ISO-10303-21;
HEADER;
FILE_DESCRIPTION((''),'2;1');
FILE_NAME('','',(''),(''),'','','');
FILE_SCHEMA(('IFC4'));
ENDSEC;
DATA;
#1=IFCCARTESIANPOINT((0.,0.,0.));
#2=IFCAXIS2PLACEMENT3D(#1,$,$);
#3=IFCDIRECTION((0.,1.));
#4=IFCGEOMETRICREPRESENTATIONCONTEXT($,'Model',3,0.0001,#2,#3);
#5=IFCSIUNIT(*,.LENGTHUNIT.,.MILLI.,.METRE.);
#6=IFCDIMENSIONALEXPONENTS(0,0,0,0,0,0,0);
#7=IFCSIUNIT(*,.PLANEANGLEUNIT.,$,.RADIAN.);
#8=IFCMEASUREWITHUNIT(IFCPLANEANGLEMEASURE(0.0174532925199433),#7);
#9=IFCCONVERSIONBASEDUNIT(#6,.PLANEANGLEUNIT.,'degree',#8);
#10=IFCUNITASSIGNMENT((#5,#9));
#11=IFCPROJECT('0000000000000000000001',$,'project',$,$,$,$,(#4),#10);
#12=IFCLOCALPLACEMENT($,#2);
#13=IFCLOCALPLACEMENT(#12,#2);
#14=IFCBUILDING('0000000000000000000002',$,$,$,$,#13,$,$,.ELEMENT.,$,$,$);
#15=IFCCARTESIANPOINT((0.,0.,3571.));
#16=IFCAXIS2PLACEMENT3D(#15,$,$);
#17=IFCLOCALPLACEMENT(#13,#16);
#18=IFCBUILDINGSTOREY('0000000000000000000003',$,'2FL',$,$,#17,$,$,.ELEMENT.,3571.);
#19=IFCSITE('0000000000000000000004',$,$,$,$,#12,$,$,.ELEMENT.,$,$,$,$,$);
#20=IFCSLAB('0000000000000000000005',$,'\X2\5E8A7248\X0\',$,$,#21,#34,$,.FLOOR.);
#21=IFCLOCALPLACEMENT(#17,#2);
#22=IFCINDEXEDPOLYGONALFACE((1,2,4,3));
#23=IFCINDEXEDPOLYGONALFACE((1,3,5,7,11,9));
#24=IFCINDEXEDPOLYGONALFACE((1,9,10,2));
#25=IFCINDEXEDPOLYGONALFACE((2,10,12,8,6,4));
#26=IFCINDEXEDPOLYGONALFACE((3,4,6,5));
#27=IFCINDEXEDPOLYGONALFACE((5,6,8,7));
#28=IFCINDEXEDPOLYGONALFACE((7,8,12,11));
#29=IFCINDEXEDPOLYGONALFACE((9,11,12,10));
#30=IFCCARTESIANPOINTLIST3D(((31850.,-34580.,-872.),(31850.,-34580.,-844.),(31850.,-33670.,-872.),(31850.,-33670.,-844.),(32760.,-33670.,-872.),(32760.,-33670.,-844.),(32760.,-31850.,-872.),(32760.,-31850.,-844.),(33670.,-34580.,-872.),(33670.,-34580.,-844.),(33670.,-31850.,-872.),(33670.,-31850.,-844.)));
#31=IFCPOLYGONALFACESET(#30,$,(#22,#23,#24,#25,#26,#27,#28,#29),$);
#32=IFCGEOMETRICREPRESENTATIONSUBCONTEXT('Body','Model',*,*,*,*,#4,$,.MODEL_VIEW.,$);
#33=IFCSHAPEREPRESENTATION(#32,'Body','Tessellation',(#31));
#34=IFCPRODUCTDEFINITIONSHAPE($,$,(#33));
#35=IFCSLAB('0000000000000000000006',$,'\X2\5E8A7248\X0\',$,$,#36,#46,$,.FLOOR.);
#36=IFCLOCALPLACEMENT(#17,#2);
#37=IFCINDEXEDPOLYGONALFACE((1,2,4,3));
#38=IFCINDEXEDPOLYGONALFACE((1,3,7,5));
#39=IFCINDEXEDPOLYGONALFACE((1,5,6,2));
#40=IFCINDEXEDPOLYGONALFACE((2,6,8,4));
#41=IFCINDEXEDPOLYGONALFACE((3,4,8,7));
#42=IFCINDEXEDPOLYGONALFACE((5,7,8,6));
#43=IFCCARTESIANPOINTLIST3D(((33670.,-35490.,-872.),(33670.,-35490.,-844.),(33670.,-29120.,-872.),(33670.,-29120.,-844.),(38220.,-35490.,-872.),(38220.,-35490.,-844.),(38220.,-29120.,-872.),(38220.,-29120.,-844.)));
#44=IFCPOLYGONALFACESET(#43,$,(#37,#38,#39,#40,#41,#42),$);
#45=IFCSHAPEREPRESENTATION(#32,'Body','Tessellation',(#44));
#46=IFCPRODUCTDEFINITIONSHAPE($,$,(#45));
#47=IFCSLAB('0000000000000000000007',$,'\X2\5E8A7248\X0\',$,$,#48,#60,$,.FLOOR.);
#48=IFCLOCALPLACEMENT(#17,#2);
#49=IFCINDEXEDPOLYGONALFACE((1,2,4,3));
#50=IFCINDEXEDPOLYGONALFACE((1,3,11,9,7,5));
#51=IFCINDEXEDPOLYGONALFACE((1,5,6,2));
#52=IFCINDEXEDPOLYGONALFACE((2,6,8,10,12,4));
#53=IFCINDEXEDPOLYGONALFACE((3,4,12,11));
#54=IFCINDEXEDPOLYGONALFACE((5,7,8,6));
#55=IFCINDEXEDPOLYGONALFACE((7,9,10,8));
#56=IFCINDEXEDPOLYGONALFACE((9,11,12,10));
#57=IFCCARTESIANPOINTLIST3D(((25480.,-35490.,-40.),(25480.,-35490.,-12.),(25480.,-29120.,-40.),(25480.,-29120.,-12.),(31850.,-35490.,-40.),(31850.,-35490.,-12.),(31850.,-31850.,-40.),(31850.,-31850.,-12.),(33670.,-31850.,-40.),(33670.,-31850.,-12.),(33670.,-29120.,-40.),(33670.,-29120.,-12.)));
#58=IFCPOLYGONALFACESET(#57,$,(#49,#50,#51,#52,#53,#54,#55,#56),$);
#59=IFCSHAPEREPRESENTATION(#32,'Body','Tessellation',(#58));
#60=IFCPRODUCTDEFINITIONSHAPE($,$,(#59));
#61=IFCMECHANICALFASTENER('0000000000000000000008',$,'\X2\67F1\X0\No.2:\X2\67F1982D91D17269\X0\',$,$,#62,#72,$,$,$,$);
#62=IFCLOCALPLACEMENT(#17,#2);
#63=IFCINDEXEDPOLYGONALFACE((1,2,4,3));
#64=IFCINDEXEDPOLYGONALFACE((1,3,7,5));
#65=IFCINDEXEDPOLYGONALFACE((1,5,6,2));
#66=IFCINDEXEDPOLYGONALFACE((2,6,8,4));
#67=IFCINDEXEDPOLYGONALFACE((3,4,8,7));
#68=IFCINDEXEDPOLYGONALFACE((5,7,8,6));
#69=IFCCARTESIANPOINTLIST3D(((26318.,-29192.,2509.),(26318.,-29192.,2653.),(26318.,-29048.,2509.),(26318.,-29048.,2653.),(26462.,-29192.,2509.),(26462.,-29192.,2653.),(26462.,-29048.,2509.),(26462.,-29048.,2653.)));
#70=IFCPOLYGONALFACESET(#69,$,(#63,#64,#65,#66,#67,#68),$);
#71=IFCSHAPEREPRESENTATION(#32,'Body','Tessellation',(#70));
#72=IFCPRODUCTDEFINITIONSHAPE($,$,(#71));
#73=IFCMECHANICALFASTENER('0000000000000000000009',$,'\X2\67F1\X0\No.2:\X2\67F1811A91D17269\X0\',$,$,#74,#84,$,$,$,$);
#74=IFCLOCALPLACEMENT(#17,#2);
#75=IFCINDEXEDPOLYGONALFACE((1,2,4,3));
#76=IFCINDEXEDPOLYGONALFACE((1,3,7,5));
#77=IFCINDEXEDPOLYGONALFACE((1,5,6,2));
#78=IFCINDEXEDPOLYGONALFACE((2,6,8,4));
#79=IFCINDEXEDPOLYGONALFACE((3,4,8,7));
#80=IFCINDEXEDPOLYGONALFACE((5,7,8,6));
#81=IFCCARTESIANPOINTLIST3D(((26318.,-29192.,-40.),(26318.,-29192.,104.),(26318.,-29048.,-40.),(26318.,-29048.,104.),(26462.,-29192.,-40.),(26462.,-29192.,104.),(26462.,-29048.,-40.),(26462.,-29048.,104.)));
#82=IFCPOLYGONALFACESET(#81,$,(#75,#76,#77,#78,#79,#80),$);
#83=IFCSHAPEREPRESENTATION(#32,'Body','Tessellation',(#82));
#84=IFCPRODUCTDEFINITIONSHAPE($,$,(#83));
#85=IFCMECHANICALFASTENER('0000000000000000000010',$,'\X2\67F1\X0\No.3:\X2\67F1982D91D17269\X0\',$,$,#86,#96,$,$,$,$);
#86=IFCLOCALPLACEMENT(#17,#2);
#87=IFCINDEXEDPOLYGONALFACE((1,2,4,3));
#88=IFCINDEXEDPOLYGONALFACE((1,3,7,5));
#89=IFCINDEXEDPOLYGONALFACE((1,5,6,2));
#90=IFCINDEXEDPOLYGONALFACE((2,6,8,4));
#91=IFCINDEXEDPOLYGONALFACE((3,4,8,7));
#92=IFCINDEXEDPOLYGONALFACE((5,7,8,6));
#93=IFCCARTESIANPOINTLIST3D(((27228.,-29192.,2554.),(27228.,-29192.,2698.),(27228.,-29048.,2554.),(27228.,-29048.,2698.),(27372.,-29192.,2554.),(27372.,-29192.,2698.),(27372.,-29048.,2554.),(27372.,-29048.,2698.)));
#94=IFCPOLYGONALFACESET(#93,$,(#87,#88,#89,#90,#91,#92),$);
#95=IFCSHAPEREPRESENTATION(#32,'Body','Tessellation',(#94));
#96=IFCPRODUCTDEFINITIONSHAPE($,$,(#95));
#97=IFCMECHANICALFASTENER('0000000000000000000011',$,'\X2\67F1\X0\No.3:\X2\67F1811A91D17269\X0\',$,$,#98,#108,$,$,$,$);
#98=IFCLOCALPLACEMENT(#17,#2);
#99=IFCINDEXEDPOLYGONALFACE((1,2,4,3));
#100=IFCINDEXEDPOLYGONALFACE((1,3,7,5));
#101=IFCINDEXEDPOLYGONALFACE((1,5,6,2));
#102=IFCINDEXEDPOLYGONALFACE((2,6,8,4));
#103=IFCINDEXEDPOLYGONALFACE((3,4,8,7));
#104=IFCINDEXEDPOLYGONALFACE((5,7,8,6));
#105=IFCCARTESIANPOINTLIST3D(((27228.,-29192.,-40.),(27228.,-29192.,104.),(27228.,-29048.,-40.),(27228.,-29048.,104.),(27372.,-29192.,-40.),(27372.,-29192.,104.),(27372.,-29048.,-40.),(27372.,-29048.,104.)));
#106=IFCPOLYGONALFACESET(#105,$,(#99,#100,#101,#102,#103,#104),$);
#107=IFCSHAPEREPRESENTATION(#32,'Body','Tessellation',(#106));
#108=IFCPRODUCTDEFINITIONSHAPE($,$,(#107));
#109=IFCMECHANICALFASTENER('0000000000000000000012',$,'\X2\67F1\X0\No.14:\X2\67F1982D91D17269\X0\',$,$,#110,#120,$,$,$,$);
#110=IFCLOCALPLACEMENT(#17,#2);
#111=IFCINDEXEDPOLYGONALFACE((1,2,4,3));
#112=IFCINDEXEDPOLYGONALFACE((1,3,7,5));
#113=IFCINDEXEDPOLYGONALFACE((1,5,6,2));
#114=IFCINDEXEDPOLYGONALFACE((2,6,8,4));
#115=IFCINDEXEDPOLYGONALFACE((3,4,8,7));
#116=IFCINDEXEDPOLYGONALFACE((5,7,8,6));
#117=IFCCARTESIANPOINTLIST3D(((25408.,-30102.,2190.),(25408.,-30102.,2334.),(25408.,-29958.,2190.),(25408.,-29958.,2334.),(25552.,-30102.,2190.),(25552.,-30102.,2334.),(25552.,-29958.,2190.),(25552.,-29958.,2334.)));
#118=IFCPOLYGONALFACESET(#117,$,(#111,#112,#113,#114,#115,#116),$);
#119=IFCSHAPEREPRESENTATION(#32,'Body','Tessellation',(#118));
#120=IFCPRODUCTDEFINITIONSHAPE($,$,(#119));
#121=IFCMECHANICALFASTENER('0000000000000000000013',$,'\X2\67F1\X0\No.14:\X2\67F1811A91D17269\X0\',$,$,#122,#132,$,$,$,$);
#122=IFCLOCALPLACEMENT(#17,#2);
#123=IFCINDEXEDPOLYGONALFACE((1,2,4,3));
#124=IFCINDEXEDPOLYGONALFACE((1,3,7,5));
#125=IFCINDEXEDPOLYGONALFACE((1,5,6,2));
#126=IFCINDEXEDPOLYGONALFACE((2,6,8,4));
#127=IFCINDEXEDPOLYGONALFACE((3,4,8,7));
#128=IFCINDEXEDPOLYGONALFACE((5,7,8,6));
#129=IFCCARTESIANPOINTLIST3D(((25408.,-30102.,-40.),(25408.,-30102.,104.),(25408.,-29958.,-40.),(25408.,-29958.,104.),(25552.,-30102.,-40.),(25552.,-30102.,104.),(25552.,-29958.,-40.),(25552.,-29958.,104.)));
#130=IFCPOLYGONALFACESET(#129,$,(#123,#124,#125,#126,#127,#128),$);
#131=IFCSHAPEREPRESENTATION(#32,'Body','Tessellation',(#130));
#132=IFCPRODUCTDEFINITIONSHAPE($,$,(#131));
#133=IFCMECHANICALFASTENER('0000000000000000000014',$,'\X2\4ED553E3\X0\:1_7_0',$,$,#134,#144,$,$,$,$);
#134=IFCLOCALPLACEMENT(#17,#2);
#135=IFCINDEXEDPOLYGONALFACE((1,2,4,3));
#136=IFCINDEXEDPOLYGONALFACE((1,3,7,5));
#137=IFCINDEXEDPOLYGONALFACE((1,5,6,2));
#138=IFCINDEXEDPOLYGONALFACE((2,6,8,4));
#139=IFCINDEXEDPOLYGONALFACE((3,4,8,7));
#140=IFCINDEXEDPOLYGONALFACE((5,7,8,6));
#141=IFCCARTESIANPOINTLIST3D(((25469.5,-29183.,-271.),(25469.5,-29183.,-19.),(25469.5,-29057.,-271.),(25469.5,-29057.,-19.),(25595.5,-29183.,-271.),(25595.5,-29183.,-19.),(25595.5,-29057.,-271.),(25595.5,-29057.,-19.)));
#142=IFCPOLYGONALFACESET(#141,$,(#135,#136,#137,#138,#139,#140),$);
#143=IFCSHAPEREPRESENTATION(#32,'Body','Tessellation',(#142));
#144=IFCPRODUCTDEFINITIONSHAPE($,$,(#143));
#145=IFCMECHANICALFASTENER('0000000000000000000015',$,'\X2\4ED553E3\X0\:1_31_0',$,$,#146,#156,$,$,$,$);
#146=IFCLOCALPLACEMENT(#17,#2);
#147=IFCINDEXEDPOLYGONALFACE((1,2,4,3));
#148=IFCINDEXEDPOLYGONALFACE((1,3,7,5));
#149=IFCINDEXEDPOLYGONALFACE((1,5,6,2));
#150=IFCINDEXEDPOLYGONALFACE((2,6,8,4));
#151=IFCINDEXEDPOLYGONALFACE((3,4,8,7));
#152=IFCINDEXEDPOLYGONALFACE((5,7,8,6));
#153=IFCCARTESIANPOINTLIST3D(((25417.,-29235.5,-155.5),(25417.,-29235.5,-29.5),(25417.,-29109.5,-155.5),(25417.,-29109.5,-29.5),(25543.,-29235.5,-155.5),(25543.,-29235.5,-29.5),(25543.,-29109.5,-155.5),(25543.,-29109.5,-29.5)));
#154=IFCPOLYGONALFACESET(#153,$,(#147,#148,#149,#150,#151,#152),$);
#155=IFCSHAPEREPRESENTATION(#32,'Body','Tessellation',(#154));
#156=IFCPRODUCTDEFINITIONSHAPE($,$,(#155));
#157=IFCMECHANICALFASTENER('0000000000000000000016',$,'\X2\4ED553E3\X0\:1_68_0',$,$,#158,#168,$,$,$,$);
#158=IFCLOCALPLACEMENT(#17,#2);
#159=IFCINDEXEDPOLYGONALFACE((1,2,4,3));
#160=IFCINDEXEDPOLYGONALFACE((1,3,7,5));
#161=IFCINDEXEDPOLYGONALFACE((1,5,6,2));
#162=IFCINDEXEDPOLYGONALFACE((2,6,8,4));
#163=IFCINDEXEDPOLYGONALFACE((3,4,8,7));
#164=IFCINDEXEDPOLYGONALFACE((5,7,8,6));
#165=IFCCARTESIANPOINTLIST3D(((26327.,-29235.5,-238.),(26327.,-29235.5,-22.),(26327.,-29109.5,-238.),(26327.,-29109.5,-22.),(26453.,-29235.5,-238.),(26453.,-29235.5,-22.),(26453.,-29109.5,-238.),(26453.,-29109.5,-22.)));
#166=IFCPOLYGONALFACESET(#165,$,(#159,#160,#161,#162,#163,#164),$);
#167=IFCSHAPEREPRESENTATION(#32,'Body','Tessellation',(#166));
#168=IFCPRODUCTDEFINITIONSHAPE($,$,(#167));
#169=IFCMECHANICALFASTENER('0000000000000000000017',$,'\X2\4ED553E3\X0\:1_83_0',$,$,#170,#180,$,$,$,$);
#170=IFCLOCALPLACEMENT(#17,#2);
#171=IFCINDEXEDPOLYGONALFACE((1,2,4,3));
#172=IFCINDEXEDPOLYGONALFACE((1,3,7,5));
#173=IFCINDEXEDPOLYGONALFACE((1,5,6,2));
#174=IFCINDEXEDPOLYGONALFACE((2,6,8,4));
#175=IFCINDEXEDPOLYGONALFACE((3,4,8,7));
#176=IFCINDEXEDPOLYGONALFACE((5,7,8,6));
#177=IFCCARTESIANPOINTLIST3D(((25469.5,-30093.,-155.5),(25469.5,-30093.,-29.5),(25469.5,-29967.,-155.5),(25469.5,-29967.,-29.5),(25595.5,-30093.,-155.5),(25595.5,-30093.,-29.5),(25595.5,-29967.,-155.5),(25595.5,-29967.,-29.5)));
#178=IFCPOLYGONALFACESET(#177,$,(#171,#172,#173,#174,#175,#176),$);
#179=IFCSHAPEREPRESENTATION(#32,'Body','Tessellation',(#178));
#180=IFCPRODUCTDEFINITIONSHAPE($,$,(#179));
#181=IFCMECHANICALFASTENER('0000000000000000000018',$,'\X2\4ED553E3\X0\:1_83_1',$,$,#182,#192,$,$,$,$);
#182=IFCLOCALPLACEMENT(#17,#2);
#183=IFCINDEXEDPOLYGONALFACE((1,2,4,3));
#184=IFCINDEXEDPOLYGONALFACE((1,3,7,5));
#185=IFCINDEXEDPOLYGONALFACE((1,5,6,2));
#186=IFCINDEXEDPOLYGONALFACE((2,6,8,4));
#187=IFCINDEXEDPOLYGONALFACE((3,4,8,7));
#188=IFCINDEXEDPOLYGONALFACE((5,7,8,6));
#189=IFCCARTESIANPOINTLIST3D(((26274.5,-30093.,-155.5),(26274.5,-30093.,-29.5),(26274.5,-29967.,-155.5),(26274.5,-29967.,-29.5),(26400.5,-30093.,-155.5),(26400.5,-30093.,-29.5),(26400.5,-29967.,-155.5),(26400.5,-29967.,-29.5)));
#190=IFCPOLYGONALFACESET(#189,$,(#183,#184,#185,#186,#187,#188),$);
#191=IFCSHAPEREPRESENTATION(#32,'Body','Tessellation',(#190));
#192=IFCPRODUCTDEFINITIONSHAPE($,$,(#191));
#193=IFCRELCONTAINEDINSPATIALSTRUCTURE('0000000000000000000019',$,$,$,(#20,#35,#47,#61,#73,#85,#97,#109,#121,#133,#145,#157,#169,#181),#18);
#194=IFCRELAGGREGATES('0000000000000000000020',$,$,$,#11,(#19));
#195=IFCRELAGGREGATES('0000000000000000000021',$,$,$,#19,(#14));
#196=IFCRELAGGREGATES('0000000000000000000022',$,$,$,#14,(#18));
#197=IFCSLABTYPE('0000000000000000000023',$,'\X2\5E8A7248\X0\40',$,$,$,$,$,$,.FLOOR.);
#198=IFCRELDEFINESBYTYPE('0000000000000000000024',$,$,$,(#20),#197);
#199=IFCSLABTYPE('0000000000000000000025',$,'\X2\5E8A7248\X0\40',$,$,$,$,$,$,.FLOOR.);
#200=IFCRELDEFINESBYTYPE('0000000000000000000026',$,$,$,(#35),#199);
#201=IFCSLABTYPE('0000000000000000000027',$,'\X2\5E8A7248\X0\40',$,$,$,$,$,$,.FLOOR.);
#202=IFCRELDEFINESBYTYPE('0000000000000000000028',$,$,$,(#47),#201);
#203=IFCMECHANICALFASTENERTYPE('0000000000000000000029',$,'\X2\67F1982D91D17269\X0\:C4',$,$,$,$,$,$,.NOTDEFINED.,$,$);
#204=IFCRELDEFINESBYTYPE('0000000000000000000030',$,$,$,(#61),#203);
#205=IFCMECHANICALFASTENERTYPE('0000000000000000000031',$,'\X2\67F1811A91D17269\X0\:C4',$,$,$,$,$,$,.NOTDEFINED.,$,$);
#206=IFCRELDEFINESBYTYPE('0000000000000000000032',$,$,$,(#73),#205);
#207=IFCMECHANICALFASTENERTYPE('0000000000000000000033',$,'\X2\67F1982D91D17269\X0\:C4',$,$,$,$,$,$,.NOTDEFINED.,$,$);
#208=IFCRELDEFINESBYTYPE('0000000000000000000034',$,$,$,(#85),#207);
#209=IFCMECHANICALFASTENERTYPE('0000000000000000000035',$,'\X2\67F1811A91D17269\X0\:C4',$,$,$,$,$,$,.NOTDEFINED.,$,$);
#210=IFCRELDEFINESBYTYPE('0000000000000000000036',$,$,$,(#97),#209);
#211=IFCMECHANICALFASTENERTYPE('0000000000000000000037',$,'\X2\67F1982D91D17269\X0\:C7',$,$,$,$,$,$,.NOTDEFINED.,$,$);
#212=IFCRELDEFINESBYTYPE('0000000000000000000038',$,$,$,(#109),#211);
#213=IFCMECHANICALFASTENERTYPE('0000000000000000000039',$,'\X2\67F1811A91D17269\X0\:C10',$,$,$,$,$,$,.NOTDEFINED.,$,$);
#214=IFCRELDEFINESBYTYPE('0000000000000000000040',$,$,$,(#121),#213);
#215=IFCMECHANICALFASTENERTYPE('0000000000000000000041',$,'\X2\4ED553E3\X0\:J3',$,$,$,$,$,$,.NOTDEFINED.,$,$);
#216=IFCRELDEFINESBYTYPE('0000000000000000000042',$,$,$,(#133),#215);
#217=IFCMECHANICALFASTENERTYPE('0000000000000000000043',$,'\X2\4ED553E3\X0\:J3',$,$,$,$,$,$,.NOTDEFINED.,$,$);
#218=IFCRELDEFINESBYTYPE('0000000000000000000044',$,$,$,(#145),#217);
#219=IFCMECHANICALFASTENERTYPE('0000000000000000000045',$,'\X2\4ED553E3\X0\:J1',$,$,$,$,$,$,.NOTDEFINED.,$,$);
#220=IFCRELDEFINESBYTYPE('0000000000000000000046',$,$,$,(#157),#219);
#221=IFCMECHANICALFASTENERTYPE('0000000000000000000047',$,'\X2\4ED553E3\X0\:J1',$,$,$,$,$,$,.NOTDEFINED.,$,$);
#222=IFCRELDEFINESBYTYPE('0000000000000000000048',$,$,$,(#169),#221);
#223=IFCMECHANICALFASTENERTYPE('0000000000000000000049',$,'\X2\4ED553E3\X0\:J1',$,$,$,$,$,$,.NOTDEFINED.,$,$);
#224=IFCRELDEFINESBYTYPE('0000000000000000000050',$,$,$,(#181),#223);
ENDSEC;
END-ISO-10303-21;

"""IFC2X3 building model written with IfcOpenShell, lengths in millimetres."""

from ifc_helpers import new_model, entity, si_unit, converted_unit, direction, frame, origin, origin_with_axes, origin_2d, place, context, subcontext, project, spatial, polyline, rectangle, outline, extrude, type_object, element, save


model = new_model("IFC2X3")

# Units and contexts
model_context = context("Model", 3, precision=0.0001, world=origin(), true_north=direction((0.0, 1.0)))
body_context = subcontext(model_context, "Body", "Model", "MODEL_VIEW")
ifc_project = project(units=[si_unit("LENGTHUNIT", "METRE", prefix="MILLI"), converted_unit("PLANEANGLEUNIT", "degree", entity("IfcPlaneAngleMeasure", 0.0174532925199433), si_unit("PLANEANGLEUNIT", "RADIAN"), dimensions=[0, 0, 0, 0, 0, 0, 0])], contexts=[model_context])

# Site, building, storey
site_placement = place(None, origin())
site = spatial("IfcSite", under=ifc_project, at=site_placement, CompositionType="ELEMENT")
building_placement = place(site_placement, origin())
building = spatial("IfcBuilding", under=site, at=building_placement, CompositionType="ELEMENT")
storey_placement = place(building_placement, frame((0.0, 0.0, 3571.0)))
storey = spatial("IfcBuildingStorey", under=building, at=storey_placement, Name="2FL", CompositionType="ELEMENT", Elevation=3571.0)

# Slabs
slab_type_1 = type_object("IfcSlabType", Name="床版40", PredefinedType="FLOOR")
slab_1_placement = place(storey_placement, frame((0.0, 0.0, -872.0), z_axis=(0.0, 0.0, 1.0), x_axis=(1.0, 0.0, 0.0)))
element("IfcSlab", 1, at=slab_1_placement, inside=storey, type_object=slab_type_1, Name="床版", PredefinedType="FLOOR", context=body_context, shape_type="SweptSolid", body=[
    extrude(outline(polyline([(31850.0, -34580.0, 0.0), (33670.0, -34580.0, 0.0), (33670.0, -31850.0, 0.0), (32760.0, -31850.0, 0.0), (32760.0, -33670.0, 0.0), (31850.0, -33670.0, 0.0), (31850.0, -34580.0, 0.0)])), origin_with_axes(), (0.0, 0.0, 1.0), 28.0),
])
slab_type_2 = type_object("IfcSlabType", Name="床版40", PredefinedType="FLOOR")
slab_2_placement = place(storey_placement, frame((0.0, 0.0, -872.0), z_axis=(0.0, 0.0, 1.0), x_axis=(1.0, 0.0, 0.0)))
element("IfcSlab", 2, at=slab_2_placement, inside=storey, type_object=slab_type_2, Name="床版", PredefinedType="FLOOR", context=body_context, shape_type="SweptSolid", body=[
    extrude(outline(polyline([(38220.0, -29120.0, 0.0), (38220.0, -35490.0, 0.0), (33670.0, -35490.0, 0.0), (33670.0, -29120.0, 0.0), (38220.0, -29120.0, 0.0)])), origin_with_axes(), (0.0, 0.0, 1.0), 28.0),
])
slab_type_3 = type_object("IfcSlabType", Name="床版40", PredefinedType="FLOOR")
slab_3_placement = place(storey_placement, frame((0.0, 0.0, -40.0), z_axis=(0.0, 0.0, 1.0), x_axis=(1.0, 0.0, 0.0)))
element("IfcSlab", 3, at=slab_3_placement, inside=storey, type_object=slab_type_3, Name="床版", PredefinedType="FLOOR", context=body_context, shape_type="SweptSolid", body=[
    extrude(outline(polyline([(33670.0, -31850.0, 0.0), (33670.0, -29120.0, 0.0), (25480.0, -29120.0, 0.0), (25480.0, -35490.0, 0.0), (31850.0, -35490.0, 0.0), (31850.0, -31850.0, 0.0), (33670.0, -31850.0, 0.0)])), origin_with_axes(), (0.0, 0.0, 1.0), 28.0),
])

# Mechanical fasteners
mechanical_fastener_type_1 = type_object("IfcMechanicalFastenerType", Name="柱頭金物:C4")
mechanical_fastener_1_placement = place(storey_placement, frame((26390.0, -29120.0, 2509.0)))
element("IfcMechanicalFastener", 4, at=mechanical_fastener_1_placement, inside=storey, type_object=mechanical_fastener_type_1, Name="柱No.2:柱頭金物", context=body_context, shape_type="SweptSolid", body=[
    extrude(rectangle(XDim=144.0, YDim=144.0, at=origin_2d()), origin_with_axes(), (0.0, 0.0, 1.0), 144.0),
])
mechanical_fastener_type_2 = type_object("IfcMechanicalFastenerType", Name="柱脚金物:C4")
mechanical_fastener_2_placement = place(storey_placement, frame((26390.0, -29120.0, -40.0)))
element("IfcMechanicalFastener", 5, at=mechanical_fastener_2_placement, inside=storey, type_object=mechanical_fastener_type_2, Name="柱No.2:柱脚金物", context=body_context, shape_type="SweptSolid", body=[
    extrude(rectangle(XDim=144.0, YDim=144.0, at=origin_2d()), origin_with_axes(), (0.0, 0.0, 1.0), 144.0),
])
mechanical_fastener_type_3 = type_object("IfcMechanicalFastenerType", Name="柱頭金物:C4")
mechanical_fastener_3_placement = place(storey_placement, frame((27300.0, -29120.0, 2554.0)))
element("IfcMechanicalFastener", 6, at=mechanical_fastener_3_placement, inside=storey, type_object=mechanical_fastener_type_3, Name="柱No.3:柱頭金物", context=body_context, shape_type="SweptSolid", body=[
    extrude(rectangle(XDim=144.0, YDim=144.0, at=origin_2d()), origin_with_axes(), (0.0, 0.0, 1.0), 144.0),
])
mechanical_fastener_type_4 = type_object("IfcMechanicalFastenerType", Name="柱脚金物:C4")
mechanical_fastener_4_placement = place(storey_placement, frame((27300.0, -29120.0, -40.0)))
element("IfcMechanicalFastener", 7, at=mechanical_fastener_4_placement, inside=storey, type_object=mechanical_fastener_type_4, Name="柱No.3:柱脚金物", context=body_context, shape_type="SweptSolid", body=[
    extrude(rectangle(XDim=144.0, YDim=144.0, at=origin_2d()), origin_with_axes(), (0.0, 0.0, 1.0), 144.0),
])
mechanical_fastener_type_5 = type_object("IfcMechanicalFastenerType", Name="柱頭金物:C7")
mechanical_fastener_5_placement = place(storey_placement, frame((25480.0, -30030.0, 2190.0)))
element("IfcMechanicalFastener", 8, at=mechanical_fastener_5_placement, inside=storey, type_object=mechanical_fastener_type_5, Name="柱No.14:柱頭金物", context=body_context, shape_type="SweptSolid", body=[
    extrude(rectangle(XDim=144.0, YDim=144.0, at=origin_2d()), origin_with_axes(), (0.0, 0.0, 1.0), 144.0),
])
mechanical_fastener_type_6 = type_object("IfcMechanicalFastenerType", Name="柱脚金物:C10")
mechanical_fastener_6_placement = place(storey_placement, frame((25480.0, -30030.0, -40.0)))
element("IfcMechanicalFastener", 9, at=mechanical_fastener_6_placement, inside=storey, type_object=mechanical_fastener_type_6, Name="柱No.14:柱脚金物", context=body_context, shape_type="SweptSolid", body=[
    extrude(rectangle(XDim=144.0, YDim=144.0, at=origin_2d()), origin_with_axes(), (0.0, 0.0, 1.0), 144.0),
])
mechanical_fastener_type_7 = type_object("IfcMechanicalFastenerType", Name="仕口:J3")
mechanical_fastener_7_placement = place(storey_placement, frame((25532.5, -29120.0, -271.0)))
element("IfcMechanicalFastener", 10, at=mechanical_fastener_7_placement, inside=storey, type_object=mechanical_fastener_type_7, Name="仕口:1_7_0", context=body_context, shape_type="SweptSolid", body=[
    extrude(rectangle(XDim=126.0, YDim=126.0, at=origin_2d()), origin_with_axes(), (0.0, 0.0, 1.0), 252.0),
])
mechanical_fastener_type_8 = type_object("IfcMechanicalFastenerType", Name="仕口:J3")
mechanical_fastener_8_placement = place(storey_placement, frame((25480.0, -29172.5, -155.5)))
element("IfcMechanicalFastener", 11, at=mechanical_fastener_8_placement, inside=storey, type_object=mechanical_fastener_type_8, Name="仕口:1_31_0", context=body_context, shape_type="SweptSolid", body=[
    extrude(rectangle(XDim=126.0, YDim=126.0, at=origin_2d()), origin_with_axes(), (0.0, 0.0, 1.0), 126.0),
])
mechanical_fastener_type_9 = type_object("IfcMechanicalFastenerType", Name="仕口:J1")
mechanical_fastener_9_placement = place(storey_placement, frame((26390.0, -29172.5, -238.0)))
element("IfcMechanicalFastener", 12, at=mechanical_fastener_9_placement, inside=storey, type_object=mechanical_fastener_type_9, Name="仕口:1_68_0", context=body_context, shape_type="SweptSolid", body=[
    extrude(rectangle(XDim=126.0, YDim=126.0, at=origin_2d()), origin_with_axes(), (0.0, 0.0, 1.0), 216.0),
])
mechanical_fastener_type_10 = type_object("IfcMechanicalFastenerType", Name="仕口:J1")
mechanical_fastener_10_placement = place(storey_placement, frame((25532.5, -30030.0, -155.5)))
element("IfcMechanicalFastener", 13, at=mechanical_fastener_10_placement, inside=storey, type_object=mechanical_fastener_type_10, Name="仕口:1_83_0", context=body_context, shape_type="SweptSolid", body=[
    extrude(rectangle(XDim=126.0, YDim=126.0, at=origin_2d()), origin_with_axes(), (0.0, 0.0, 1.0), 126.0),
])
mechanical_fastener_type_11 = type_object("IfcMechanicalFastenerType", Name="仕口:J1")
mechanical_fastener_11_placement = place(storey_placement, frame((26337.5, -30030.0, -155.5)))
element("IfcMechanicalFastener", 14, at=mechanical_fastener_11_placement, inside=storey, type_object=mechanical_fastener_type_11, Name="仕口:1_83_1", context=body_context, shape_type="SweptSolid", body=[
    extrude(rectangle(XDim=126.0, YDim=126.0, at=origin_2d()), origin_with_axes(), (0.0, 0.0, 1.0), 126.0),
])

save(model, "model.ifc")
